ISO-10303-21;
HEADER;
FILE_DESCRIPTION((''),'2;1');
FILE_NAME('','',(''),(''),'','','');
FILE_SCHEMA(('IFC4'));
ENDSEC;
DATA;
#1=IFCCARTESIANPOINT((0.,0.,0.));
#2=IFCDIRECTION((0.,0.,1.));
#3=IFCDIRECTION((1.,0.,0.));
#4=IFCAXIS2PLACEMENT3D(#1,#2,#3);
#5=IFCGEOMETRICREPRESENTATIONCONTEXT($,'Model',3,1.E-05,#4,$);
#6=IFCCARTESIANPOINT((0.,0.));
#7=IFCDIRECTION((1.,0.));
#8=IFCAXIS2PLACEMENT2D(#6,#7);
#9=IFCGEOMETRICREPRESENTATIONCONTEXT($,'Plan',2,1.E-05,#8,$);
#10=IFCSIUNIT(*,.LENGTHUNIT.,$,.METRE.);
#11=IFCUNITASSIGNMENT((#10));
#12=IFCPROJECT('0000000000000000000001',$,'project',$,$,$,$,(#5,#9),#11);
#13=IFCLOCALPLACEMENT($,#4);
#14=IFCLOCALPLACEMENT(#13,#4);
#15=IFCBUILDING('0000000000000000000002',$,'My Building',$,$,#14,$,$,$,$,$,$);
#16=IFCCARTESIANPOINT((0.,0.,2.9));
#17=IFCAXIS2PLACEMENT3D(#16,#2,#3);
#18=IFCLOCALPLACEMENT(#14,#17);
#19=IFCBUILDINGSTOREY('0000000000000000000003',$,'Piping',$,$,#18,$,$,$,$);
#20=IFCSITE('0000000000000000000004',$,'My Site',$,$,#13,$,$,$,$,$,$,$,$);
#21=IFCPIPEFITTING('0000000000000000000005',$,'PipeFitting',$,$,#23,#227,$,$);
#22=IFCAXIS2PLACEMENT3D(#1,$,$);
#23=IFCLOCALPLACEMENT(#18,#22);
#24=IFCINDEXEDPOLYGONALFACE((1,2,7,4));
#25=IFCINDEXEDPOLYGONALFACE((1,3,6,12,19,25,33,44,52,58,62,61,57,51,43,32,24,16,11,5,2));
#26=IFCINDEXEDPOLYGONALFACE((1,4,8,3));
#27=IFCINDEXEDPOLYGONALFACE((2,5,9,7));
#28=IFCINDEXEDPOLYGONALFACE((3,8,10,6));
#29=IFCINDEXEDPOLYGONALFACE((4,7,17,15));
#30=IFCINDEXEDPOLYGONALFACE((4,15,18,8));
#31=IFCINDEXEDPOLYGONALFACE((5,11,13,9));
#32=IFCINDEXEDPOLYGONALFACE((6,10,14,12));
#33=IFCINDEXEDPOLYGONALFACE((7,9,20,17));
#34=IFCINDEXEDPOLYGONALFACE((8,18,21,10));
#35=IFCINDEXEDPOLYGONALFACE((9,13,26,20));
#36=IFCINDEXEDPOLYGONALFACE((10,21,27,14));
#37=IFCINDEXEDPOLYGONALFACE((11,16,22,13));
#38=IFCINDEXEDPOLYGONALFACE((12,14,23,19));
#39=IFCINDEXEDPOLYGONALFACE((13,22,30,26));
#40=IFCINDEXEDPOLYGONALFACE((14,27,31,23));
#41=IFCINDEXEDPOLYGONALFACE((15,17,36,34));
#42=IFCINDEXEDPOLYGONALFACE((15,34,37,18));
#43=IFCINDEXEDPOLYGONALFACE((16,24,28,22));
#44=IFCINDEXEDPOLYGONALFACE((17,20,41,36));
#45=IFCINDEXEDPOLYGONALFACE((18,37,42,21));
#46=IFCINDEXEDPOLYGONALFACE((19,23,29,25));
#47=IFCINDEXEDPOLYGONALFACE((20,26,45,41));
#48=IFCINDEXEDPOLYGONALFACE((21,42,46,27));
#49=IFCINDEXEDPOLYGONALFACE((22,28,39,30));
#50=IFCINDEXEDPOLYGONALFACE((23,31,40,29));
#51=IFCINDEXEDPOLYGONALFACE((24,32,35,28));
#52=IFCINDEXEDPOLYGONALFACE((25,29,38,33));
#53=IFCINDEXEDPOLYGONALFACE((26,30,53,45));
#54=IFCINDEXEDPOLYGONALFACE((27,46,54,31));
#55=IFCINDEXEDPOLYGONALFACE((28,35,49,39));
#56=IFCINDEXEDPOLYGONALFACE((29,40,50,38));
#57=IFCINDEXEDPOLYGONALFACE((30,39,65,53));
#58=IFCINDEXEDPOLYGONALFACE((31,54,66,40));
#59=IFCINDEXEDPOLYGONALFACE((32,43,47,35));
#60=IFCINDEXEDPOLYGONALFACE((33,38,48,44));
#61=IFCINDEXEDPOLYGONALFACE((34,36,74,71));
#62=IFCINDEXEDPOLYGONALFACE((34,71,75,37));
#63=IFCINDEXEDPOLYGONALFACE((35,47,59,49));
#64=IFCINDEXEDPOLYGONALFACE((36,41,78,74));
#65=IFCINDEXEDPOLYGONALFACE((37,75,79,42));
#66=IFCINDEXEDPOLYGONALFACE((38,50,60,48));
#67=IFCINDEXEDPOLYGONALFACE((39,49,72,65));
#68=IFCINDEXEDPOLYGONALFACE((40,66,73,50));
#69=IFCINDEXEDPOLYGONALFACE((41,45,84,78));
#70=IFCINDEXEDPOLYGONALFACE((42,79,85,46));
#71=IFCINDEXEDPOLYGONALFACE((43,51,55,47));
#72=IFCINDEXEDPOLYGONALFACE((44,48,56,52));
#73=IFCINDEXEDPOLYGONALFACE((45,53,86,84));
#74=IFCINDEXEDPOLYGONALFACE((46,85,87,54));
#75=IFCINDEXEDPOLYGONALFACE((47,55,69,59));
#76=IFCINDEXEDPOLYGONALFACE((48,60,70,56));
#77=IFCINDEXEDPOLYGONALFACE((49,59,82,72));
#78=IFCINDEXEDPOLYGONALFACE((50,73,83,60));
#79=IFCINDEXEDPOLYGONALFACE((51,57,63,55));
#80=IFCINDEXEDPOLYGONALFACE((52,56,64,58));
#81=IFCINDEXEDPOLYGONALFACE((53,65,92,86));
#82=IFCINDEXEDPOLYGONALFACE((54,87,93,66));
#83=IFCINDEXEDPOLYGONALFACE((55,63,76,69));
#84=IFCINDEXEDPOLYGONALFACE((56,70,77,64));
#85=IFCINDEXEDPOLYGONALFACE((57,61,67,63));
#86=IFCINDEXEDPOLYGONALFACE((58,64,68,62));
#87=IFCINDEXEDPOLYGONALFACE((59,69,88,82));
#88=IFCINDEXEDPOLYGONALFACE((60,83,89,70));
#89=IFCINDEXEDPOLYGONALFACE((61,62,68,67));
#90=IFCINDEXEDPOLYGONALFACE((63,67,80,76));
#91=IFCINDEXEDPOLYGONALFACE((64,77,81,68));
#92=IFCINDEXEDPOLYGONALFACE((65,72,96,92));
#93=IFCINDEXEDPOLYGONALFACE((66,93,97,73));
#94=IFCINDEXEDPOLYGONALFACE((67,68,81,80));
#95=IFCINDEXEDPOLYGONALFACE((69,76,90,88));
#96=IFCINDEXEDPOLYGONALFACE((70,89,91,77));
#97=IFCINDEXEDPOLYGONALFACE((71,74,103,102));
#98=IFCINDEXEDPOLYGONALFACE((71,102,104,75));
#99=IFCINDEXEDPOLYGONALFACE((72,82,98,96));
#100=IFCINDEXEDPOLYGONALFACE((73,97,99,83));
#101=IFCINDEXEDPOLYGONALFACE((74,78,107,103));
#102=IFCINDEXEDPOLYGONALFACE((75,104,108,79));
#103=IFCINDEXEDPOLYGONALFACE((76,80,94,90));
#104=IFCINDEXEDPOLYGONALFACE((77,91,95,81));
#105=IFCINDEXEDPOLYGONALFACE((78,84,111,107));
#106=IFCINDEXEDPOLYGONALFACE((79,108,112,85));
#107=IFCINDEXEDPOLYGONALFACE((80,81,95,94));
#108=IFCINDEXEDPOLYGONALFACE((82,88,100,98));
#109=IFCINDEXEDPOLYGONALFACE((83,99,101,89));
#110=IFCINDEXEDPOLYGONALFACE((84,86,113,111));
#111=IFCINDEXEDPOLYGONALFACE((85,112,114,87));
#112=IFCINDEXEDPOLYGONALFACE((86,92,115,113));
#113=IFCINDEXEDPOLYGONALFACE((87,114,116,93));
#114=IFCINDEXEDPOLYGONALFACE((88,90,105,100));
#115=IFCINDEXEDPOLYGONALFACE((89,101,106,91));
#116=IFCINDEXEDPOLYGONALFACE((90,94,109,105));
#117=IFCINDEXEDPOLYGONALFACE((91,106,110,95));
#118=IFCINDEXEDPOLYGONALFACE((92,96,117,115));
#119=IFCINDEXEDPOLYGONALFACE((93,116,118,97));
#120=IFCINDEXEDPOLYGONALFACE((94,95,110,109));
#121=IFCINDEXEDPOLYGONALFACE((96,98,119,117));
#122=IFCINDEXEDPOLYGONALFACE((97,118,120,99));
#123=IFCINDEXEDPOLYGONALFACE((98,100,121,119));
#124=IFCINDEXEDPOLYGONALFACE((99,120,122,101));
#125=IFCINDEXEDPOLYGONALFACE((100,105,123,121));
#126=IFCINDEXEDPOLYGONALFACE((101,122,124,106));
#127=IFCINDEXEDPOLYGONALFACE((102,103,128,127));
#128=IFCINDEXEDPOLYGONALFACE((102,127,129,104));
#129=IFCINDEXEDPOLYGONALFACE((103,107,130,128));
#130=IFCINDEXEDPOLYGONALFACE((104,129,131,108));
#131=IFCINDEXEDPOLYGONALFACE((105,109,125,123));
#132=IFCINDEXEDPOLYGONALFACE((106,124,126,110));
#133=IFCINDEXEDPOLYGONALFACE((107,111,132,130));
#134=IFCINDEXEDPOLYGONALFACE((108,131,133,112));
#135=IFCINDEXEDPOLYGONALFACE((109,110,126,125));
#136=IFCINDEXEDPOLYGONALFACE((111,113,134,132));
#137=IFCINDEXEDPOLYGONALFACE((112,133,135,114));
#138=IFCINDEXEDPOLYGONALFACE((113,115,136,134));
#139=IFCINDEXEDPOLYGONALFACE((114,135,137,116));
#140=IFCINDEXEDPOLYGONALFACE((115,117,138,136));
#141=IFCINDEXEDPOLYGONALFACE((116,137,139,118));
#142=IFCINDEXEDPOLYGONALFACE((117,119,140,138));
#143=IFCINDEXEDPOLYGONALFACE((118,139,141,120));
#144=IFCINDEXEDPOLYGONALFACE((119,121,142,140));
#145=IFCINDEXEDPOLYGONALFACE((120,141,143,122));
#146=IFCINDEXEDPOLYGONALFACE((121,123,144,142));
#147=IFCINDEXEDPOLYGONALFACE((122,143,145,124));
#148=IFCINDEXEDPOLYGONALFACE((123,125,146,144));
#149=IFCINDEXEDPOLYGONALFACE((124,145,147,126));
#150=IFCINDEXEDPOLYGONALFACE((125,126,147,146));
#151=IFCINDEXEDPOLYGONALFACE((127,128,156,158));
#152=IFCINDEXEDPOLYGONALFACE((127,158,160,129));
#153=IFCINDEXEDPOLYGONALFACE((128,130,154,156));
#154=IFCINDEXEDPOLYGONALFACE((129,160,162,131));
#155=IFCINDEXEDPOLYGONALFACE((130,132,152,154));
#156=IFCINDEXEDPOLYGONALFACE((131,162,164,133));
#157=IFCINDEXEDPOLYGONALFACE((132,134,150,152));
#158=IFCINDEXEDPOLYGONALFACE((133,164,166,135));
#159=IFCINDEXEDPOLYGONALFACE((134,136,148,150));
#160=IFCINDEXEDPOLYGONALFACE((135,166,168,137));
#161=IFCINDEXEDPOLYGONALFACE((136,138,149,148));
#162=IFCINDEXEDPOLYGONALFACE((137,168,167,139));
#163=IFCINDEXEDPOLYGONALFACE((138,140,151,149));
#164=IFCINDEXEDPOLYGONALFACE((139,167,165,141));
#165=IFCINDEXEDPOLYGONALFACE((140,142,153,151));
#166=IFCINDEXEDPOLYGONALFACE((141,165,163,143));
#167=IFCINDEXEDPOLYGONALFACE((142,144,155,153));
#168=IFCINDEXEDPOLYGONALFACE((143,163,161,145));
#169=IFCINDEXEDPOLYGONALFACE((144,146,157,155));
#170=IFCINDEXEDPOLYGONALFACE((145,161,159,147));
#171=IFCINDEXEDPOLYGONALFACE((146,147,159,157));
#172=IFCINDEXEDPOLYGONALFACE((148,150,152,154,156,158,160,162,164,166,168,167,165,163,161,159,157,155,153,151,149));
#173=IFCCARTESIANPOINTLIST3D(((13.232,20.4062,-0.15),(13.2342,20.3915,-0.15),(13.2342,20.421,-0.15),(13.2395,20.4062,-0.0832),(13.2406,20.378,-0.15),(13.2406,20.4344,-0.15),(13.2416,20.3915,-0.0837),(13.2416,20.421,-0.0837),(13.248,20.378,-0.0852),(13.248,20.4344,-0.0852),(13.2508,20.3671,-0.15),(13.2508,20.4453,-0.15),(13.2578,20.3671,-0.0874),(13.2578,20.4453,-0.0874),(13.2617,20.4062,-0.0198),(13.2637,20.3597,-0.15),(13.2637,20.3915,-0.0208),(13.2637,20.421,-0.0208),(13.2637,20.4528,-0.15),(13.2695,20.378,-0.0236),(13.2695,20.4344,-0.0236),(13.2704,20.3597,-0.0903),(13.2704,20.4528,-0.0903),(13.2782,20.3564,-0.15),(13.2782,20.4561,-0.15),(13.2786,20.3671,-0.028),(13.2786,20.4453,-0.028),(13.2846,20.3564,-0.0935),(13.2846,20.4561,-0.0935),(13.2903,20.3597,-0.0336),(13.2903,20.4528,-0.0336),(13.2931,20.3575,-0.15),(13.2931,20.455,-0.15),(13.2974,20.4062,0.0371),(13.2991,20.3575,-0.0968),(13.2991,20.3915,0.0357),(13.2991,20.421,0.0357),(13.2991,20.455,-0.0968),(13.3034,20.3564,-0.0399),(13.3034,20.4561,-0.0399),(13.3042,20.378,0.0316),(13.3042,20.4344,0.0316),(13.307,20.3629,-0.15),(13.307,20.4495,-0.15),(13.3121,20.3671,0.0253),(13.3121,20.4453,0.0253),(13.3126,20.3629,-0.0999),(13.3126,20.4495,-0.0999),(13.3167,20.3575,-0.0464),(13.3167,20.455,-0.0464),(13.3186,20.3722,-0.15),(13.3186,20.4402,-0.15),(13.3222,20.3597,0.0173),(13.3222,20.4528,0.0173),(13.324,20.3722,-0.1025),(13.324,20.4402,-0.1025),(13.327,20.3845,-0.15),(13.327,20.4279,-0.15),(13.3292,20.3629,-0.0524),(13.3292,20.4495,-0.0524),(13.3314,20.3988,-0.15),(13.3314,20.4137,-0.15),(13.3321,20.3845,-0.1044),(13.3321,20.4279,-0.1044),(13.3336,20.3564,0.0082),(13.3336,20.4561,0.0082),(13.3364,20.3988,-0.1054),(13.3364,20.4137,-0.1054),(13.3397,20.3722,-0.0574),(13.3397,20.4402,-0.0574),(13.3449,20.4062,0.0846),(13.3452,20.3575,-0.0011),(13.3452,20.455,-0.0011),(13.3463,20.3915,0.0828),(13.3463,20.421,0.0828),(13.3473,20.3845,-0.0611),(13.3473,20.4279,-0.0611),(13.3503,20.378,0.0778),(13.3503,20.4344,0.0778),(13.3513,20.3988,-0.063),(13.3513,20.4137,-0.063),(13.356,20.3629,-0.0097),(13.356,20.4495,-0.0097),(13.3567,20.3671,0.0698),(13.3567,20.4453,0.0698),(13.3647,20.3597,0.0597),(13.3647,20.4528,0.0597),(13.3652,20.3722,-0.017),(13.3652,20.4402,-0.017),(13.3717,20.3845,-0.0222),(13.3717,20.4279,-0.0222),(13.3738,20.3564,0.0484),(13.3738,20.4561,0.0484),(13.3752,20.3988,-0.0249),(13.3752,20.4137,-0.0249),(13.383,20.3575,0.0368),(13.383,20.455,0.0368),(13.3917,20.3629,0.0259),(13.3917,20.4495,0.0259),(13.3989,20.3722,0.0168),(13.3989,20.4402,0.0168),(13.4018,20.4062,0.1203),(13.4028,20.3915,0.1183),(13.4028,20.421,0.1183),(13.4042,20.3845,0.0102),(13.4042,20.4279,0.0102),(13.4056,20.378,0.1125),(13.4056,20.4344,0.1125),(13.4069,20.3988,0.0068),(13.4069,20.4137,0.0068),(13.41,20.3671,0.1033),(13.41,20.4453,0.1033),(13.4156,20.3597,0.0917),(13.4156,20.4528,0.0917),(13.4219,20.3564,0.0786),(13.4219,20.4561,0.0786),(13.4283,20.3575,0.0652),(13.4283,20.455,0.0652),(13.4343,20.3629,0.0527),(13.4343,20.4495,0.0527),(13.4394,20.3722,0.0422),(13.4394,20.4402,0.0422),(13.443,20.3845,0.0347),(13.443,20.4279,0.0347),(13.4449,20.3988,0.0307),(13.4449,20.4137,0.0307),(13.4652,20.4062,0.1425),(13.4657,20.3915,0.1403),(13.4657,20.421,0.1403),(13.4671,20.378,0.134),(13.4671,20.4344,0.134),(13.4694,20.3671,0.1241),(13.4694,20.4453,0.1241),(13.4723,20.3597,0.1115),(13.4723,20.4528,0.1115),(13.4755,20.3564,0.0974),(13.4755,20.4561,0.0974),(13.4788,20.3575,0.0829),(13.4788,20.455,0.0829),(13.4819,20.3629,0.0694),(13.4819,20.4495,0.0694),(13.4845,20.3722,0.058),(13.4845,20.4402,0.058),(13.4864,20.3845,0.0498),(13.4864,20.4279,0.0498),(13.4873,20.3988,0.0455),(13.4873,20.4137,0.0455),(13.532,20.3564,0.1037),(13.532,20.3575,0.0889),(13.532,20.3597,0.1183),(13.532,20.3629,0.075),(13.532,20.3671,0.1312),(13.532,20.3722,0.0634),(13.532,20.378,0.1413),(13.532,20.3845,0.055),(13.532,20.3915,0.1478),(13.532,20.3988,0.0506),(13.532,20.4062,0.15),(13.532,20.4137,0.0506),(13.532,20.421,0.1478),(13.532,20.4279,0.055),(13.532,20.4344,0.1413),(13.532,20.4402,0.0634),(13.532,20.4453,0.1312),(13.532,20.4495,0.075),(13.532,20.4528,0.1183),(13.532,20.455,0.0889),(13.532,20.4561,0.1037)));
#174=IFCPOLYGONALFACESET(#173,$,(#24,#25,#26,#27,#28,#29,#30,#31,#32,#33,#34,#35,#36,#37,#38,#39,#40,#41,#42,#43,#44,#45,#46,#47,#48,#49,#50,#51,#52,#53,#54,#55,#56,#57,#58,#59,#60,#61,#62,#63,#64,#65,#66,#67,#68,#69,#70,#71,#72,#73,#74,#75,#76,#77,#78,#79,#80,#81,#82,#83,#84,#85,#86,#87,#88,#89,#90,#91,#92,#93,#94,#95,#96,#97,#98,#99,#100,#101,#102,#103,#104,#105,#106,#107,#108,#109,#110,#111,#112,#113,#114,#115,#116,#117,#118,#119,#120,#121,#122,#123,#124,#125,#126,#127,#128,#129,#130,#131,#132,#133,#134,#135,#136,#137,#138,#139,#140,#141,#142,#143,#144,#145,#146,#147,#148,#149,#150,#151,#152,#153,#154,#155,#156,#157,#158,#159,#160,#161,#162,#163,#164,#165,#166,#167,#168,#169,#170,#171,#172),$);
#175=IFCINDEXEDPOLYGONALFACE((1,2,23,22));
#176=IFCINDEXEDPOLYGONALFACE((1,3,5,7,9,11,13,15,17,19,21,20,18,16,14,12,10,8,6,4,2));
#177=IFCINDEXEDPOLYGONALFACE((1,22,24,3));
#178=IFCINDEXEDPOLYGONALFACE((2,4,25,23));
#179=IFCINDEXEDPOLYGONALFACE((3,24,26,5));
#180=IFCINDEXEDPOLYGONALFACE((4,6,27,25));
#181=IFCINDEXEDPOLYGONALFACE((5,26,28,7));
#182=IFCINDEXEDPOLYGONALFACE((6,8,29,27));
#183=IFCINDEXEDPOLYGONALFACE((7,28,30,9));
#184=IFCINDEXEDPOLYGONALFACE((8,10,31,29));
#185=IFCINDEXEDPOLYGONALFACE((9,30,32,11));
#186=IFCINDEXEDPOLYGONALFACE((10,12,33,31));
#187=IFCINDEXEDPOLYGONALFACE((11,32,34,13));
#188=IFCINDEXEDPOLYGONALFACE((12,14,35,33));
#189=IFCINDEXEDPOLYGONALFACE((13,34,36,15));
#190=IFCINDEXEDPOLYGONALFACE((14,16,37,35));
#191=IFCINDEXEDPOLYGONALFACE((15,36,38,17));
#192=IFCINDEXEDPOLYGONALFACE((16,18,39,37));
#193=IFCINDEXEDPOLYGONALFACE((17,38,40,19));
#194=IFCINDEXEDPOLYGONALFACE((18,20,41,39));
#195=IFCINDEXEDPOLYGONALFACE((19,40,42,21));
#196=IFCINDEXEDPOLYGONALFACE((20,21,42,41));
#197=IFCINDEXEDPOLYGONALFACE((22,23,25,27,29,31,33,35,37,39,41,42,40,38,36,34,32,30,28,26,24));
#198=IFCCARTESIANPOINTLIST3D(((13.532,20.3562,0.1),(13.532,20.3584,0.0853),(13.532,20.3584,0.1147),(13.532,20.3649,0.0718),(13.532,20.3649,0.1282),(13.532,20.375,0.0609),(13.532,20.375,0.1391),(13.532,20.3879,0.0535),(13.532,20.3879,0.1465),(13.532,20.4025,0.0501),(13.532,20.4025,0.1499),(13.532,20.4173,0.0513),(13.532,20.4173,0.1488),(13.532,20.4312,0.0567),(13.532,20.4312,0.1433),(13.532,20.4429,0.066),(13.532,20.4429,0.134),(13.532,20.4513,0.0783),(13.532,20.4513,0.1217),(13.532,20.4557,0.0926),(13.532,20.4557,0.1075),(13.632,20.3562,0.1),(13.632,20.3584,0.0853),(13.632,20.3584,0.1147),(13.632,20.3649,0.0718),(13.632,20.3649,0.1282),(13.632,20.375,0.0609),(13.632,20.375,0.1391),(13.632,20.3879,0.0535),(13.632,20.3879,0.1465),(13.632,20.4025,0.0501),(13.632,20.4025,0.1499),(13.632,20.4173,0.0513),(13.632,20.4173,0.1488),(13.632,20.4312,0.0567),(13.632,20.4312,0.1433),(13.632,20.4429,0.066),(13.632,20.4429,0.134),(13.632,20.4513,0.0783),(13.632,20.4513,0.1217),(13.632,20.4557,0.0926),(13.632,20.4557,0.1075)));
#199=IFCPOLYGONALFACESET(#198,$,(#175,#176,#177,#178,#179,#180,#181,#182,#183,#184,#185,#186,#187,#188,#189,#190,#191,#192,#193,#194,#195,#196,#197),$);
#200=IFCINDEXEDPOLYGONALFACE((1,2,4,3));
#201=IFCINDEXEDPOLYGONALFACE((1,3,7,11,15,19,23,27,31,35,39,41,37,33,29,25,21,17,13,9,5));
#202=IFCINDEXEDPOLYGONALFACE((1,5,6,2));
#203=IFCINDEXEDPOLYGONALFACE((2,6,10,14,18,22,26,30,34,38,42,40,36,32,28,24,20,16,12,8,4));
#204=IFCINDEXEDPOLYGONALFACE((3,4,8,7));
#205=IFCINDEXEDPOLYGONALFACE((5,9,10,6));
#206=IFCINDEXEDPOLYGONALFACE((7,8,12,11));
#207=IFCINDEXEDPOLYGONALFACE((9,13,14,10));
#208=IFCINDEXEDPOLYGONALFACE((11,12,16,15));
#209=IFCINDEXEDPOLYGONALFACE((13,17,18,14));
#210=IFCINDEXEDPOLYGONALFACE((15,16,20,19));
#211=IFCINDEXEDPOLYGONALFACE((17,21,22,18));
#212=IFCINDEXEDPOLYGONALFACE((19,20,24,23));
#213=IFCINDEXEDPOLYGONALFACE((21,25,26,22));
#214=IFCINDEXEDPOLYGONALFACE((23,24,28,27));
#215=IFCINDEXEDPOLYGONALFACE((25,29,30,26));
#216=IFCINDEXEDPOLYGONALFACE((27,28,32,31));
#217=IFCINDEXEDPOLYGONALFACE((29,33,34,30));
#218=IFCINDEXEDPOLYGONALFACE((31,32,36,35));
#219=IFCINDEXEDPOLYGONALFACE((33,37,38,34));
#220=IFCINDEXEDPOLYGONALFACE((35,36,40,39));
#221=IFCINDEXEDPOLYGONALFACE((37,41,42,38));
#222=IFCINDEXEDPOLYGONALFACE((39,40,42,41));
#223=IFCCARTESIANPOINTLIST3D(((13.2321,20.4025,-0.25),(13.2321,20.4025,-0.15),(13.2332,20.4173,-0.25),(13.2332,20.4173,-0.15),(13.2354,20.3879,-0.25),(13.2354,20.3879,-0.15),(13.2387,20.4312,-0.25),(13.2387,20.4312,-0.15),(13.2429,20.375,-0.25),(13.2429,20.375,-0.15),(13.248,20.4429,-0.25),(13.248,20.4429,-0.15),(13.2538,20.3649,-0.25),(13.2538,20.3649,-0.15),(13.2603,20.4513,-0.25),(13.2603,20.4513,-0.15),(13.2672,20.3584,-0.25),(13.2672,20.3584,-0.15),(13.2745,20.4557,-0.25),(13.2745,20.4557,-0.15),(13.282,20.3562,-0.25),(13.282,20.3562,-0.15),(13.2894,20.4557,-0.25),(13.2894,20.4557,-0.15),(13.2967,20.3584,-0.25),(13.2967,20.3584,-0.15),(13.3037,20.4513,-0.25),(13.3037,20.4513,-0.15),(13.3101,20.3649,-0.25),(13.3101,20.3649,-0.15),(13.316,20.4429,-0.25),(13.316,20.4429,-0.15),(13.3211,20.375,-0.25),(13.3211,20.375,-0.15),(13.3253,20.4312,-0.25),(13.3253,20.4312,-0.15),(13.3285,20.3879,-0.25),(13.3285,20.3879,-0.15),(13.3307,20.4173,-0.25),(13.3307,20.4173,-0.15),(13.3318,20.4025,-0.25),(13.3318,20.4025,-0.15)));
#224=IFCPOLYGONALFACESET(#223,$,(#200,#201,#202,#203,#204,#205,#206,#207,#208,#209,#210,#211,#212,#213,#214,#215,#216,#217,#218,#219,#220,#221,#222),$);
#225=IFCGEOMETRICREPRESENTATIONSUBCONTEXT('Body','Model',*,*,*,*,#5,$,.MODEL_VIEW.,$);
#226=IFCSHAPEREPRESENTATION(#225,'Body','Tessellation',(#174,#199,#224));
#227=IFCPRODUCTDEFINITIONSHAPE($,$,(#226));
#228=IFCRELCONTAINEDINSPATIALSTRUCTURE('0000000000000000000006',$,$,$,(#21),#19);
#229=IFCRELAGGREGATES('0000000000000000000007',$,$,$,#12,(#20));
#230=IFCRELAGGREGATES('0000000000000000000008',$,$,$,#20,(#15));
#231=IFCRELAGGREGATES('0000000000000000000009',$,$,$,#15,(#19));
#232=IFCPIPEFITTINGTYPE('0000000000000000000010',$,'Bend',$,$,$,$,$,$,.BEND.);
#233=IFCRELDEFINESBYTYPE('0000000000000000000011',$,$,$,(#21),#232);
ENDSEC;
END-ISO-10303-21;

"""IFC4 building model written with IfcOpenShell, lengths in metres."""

from ifc_helpers import new_model, entity, si_unit, frame, origin_with_axes, origin_2d_with_axis, place, context, subcontext, project, spatial, circle, extrude, source, transform, mapped, type_object, type_shapes, element, save


model = new_model("IFC4")

# Units and contexts
model_context = context("Model", 3, precision=1e-05, world=origin_with_axes())
plan_context = context("Plan", 2, precision=1e-05, world=origin_2d_with_axis())
body_context = subcontext(model_context, "Body", "Model", "MODEL_VIEW")
ifc_project = project(units=[si_unit("LENGTHUNIT", "METRE")], contexts=[model_context, plan_context])

# Site, building, storey
site_placement = place(None, origin_with_axes())
site = spatial("IfcSite", under=ifc_project, at=site_placement, Name="My Site")
building_placement = place(site_placement, origin_with_axes())
building = spatial("IfcBuilding", under=site, at=building_placement, Name="My Building")
storey_placement = place(building_placement, frame((0.0, 0.0, 2.9), z_axis=(0.0, 0.0, 1.0), x_axis=(1.0, 0.0, 0.0)))
storey = spatial("IfcBuildingStorey", under=building, at=storey_placement, Name="Piping")

# Pipe fitting
pipe_fitting_type = type_object("IfcPipeFittingType", Name="Bend", PredefinedType="BEND")
shared_shape = source(origin_with_axes(), body_context, "Body", "SolidModel", [
    entity("IfcSweptDiskSolid", entity("IfcIndexedPolyCurve", entity("IfcCartesianPointList3D", [[0.0, 0.0, 0.1], [0.0, -0.0732, 0.2768], [0.0, -0.25, 0.35]]), [entity("IfcArcIndex", [1, 2, 3])]), 0.05),
    extrude(circle(Radius=0.05), origin_with_axes(), (0.0, 0.0, 1.0), 0.1),
    extrude(circle(Radius=0.05), frame((0.0, -0.25, 0.35), z_axis=(0.0, -1.0, -0.000001), x_axis=(1.0, 0.0, 0.0)), (0.0, 0.0, 1.0), 0.1),
])
type_shapes(pipe_fitting_type, [shared_shape])
for number, where, z_axis, x_axis, name in (
    (1, (13.632, 20.4062, 0.1), (-1.0, 0.0, 0.000001), (0.0, -1.0, 0.0), "PipeFitting"),
):
    element("IfcPipeFitting", number, at=place(storey_placement, frame(where, z_axis=z_axis, x_axis=x_axis)), inside=storey, type_object=pipe_fitting_type, Name=name, context=body_context, shape_type="MappedRepresentation", body=[
        mapped(shared_shape, transform((0.0, 0.0, 0.0), x_axis=(1.0, 0.0, 0.0), y_axis=(0.0, 1.0, 0.0), z_axis=(0.0, 0.0, 1.0), scale=1.0)),
    ])

save(model, "model.ifc")
